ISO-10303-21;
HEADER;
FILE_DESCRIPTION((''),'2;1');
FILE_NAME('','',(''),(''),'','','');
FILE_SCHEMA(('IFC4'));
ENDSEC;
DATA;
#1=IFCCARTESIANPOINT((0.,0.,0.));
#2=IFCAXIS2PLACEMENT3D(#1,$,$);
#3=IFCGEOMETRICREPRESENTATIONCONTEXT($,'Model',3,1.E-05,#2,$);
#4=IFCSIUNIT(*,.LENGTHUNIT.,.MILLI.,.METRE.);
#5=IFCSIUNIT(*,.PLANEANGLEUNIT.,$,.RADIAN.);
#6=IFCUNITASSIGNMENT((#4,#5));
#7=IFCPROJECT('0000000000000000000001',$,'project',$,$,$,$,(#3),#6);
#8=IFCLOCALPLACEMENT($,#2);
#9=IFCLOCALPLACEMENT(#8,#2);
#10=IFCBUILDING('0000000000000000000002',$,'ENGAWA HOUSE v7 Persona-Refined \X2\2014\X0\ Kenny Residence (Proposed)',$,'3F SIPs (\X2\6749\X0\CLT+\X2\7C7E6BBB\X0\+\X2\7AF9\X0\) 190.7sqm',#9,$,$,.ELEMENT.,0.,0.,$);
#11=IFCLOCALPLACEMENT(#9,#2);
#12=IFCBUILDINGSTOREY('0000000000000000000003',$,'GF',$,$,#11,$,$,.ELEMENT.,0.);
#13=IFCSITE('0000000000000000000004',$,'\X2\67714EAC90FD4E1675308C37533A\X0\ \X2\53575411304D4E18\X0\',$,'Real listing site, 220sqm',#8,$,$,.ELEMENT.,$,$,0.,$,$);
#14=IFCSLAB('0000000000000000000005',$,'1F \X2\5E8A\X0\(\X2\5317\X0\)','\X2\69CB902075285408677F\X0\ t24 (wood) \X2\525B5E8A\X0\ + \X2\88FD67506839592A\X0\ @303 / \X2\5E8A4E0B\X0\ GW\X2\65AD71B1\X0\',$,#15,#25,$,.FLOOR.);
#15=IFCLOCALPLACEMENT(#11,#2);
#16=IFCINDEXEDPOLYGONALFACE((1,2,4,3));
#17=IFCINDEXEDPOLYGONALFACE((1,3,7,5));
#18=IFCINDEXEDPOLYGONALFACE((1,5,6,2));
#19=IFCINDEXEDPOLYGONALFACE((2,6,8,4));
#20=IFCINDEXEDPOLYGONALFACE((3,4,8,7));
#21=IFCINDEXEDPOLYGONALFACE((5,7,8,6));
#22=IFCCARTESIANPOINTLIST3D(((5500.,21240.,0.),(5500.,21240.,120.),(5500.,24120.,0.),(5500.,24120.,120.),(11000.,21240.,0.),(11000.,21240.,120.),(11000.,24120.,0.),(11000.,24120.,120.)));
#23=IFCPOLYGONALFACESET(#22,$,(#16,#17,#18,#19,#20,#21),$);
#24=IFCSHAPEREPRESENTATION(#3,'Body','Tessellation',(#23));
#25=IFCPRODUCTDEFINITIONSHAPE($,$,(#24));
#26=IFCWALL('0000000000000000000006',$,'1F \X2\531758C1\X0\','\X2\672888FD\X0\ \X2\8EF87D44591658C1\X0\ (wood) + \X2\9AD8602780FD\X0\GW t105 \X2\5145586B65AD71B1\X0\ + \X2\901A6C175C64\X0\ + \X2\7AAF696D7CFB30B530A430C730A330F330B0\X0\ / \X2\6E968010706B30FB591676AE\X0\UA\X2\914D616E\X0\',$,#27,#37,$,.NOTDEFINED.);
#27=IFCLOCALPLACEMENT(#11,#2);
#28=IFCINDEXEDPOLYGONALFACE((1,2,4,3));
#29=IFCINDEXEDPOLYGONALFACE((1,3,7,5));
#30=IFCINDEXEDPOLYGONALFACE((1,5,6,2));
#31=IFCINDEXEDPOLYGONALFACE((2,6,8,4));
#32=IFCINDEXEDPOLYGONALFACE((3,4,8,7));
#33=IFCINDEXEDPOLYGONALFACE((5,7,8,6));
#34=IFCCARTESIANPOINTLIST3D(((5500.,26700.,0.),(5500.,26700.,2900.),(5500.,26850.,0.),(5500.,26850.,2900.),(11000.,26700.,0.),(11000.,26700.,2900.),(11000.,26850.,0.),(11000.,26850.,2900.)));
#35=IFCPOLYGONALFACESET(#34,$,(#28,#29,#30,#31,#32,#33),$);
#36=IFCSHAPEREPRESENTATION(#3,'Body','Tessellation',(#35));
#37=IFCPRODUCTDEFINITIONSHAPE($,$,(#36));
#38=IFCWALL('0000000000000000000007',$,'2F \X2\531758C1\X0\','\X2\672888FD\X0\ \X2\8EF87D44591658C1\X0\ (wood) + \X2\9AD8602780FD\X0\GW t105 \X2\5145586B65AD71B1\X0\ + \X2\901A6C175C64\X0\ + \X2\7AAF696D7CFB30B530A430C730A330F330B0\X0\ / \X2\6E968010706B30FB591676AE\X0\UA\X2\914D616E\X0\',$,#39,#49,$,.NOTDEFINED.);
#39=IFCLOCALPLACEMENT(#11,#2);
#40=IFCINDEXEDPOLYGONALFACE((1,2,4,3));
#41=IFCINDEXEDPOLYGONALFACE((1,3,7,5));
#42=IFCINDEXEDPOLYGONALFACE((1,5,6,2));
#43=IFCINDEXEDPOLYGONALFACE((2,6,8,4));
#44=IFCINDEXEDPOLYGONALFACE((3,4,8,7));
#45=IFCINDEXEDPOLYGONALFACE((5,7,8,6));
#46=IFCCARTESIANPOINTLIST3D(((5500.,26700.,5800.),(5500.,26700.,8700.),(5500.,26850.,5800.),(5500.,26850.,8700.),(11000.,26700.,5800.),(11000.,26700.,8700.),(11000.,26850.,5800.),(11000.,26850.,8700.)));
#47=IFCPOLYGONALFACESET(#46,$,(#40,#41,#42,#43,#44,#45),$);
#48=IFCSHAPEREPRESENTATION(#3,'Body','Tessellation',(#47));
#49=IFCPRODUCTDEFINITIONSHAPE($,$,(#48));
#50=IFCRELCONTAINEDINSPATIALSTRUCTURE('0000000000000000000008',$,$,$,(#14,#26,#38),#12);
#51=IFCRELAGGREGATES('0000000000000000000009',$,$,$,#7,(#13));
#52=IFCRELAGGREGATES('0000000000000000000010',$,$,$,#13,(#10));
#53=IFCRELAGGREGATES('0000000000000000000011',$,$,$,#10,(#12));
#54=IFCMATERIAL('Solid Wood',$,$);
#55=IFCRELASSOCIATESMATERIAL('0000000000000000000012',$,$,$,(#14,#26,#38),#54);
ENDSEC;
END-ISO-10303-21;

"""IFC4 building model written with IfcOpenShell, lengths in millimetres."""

from ifc_helpers import new_model, si_unit, frame, frame_2d, origin, place, context, project, spatial, rectangle, extrude, material, element, save


model = new_model("IFC4")

# Units and contexts
model_context = context("Model", 3, precision=1e-05, world=origin())
ifc_project = project(units=[si_unit("LENGTHUNIT", "METRE", prefix="MILLI"), si_unit("PLANEANGLEUNIT", "RADIAN")], contexts=[model_context])

# Site, building, storey
site_placement = place(None, origin())
site = spatial("IfcSite", under=ifc_project, at=site_placement, Name="東京都世田谷区 南向き丘", ObjectType="Real listing site, 220sqm", CompositionType="ELEMENT", RefElevation=0.0)
building_placement = place(site_placement, origin())
building = spatial("IfcBuilding", under=site, at=building_placement, Name="ENGAWA HOUSE v7 Persona-Refined — Kenny Residence (Proposed)", ObjectType="3F SIPs (杉CLT+籾殻+竹) 190.7sqm", CompositionType="ELEMENT", ElevationOfRefHeight=0.0, ElevationOfTerrain=0.0)
storey_placement = place(building_placement, origin())
storey = spatial("IfcBuildingStorey", under=building, at=storey_placement, Name="GF", CompositionType="ELEMENT", Elevation=0.0)

# Slab
ifc_material_1 = material(Name="Solid Wood")
slab_1_placement = place(storey_placement, frame((2750.0, 10620.0, 0.0)))
element("IfcSlab", 1, at=slab_1_placement, inside=storey, material=ifc_material_1, Name="1F 床(北)", Description="構造用合板 t24 (wood) 剛床 + 製材根太 @303 / 床下 GW断熱", PredefinedType="FLOOR", context=model_context, shape_type="SweptSolid", body=[
    extrude(rectangle(XDim=5500.0, YDim=2880.0, at=frame_2d((2750.0, 1440.0))), frame((2750.0, 10620.0, 0.0)), (0.0, 0.0, 1.0), 120.0),
])

# Wall
wall_1_placement = place(storey_placement, frame((2750.0, 13350.0, 0.0)))
element("IfcWall", 2, at=wall_1_placement, inside=storey, material=ifc_material_1, Name="1F 北壁", Description="木製 軸組外壁 (wood) + 高性能GW t105 充填断熱 + 通気層 + 窯業系サイディング / 準耐火・外皮UA配慮", PredefinedType="NOTDEFINED", context=model_context, shape_type="SweptSolid", body=[
    extrude(rectangle(XDim=5500.0, YDim=150.0, at=frame_2d((2750.0, 75.0))), frame((2750.0, 13350.0, 0.0)), (0.0, 0.0, 1.0), 2900.0),
])

# Wall
wall_2_placement = place(storey_placement, frame((2750.0, 13350.0, 2900.0)))
element("IfcWall", 3, at=wall_2_placement, inside=storey, material=ifc_material_1, Name="2F 北壁", Description="木製 軸組外壁 (wood) + 高性能GW t105 充填断熱 + 通気層 + 窯業系サイディング / 準耐火・外皮UA配慮", PredefinedType="NOTDEFINED", context=model_context, shape_type="SweptSolid", body=[
    extrude(rectangle(XDim=5500.0, YDim=150.0, at=frame_2d((2750.0, 75.0))), frame((2750.0, 13350.0, 2900.0)), (0.0, 0.0, 1.0), 2900.0),
])

save(model, "model.ifc")
